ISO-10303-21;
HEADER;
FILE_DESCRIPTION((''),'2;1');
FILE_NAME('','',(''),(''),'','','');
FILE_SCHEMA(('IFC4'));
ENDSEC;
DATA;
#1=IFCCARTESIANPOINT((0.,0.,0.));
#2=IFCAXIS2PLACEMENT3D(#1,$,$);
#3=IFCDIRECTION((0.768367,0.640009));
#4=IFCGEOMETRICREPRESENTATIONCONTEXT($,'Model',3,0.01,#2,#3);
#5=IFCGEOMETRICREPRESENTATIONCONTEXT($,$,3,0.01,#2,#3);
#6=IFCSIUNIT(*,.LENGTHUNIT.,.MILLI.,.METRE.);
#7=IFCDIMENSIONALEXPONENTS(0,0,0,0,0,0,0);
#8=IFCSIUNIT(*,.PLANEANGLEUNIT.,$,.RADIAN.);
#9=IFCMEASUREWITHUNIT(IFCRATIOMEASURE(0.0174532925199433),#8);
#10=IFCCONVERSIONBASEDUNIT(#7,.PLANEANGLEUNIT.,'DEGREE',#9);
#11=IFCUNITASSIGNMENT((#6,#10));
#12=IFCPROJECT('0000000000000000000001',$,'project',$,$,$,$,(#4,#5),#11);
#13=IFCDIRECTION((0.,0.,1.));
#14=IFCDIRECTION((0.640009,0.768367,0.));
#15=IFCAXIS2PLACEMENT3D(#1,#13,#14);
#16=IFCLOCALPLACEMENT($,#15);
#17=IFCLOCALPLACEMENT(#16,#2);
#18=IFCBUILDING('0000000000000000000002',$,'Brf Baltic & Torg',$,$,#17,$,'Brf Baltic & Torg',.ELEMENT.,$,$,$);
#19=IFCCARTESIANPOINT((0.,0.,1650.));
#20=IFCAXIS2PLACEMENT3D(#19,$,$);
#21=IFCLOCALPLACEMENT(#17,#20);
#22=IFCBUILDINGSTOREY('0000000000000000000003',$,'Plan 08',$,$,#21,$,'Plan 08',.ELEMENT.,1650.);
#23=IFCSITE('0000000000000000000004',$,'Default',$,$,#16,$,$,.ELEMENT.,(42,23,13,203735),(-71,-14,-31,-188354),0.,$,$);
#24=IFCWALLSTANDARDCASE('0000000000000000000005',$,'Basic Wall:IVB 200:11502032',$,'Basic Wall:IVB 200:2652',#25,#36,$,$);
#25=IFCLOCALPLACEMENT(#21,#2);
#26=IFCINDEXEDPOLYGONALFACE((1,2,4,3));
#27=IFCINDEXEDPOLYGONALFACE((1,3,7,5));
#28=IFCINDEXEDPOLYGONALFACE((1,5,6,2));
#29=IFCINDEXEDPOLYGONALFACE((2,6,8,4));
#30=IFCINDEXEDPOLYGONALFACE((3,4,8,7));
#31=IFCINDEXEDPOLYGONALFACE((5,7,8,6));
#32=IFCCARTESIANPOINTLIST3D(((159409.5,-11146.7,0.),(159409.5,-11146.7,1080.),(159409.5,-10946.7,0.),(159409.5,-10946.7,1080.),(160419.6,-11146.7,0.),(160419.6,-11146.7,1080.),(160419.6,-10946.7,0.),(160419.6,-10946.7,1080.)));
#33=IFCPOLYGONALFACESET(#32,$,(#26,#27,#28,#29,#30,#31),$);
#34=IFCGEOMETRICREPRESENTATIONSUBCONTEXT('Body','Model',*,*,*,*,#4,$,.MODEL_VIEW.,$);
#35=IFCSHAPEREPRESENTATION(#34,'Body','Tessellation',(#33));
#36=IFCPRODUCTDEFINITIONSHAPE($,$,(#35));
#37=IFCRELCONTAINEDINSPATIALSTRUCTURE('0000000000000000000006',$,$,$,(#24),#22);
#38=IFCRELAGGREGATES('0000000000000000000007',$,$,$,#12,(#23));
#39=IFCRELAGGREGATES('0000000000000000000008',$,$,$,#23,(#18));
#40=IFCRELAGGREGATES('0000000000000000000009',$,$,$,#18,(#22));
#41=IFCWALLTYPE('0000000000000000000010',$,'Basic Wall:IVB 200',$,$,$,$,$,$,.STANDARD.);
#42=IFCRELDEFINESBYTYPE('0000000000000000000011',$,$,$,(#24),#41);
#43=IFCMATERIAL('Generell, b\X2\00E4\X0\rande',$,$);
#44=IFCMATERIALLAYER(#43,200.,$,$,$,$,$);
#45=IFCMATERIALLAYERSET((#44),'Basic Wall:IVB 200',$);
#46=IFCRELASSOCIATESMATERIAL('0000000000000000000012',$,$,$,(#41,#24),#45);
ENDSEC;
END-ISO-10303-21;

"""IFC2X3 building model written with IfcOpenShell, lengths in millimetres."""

from ifc_helpers import new_model, entity, si_unit, converted_unit, direction, frame, frame_2d, origin, place, context, subcontext, project, spatial, rectangle, extrude, clip, halfspace, material, layer, layer_set, layer_usage, type_object, element, save


model = new_model("IFC2X3")

# Units and contexts
model_context = context("Model", 3, precision=0.01, world=origin(), true_north=direction((0.768367, 0.640009)))
context_of_model = context(None, 3, precision=0.01, world=origin(), true_north=direction((0.768367, 0.640009)))
body_context = subcontext(model_context, "Body", "Model", "MODEL_VIEW")
ifc_project = project(units=[si_unit("LENGTHUNIT", "METRE", prefix="MILLI"), converted_unit("PLANEANGLEUNIT", "DEGREE", entity("IfcRatioMeasure", 0.0174532925199433), si_unit("PLANEANGLEUNIT", "RADIAN"), dimensions=[0, 0, 0, 0, 0, 0, 0])], contexts=[model_context, context_of_model])

# Site, building, storey
site_placement = place(None, frame((0.0, 0.0, 0.0), z_axis=(0.0, 0.0, 1.0), x_axis=(0.640009, 0.768367, 0.0)))
site = spatial("IfcSite", under=ifc_project, at=site_placement, Name="Default", CompositionType="ELEMENT", RefLatitude=(42, 23, 13, 203735), RefLongitude=(-71, -14, -31, -188354), RefElevation=0.0)
building_placement = place(site_placement, origin())
building = spatial("IfcBuilding", under=site, at=building_placement, Name="Brf Baltic & Torg", LongName="Brf Baltic & Torg", CompositionType="ELEMENT")
storey_placement = place(building_placement, frame((0.0, 0.0, 1650.0)))
storey = spatial("IfcBuildingStorey", under=building, at=storey_placement, Name="Plan 08", LongName="Plan 08", CompositionType="ELEMENT", Elevation=1650.0)

# Shared definitions
ifc_material_1 = material(Name="Generell, bärande")
ifc_layer = layer(ifc_material_1, 200.0)
ifc_layer_set = layer_set([ifc_layer], Name="Basic Wall:IVB 200")
wall_type = type_object("IfcWallType", Name="Basic Wall:IVB 200", PredefinedType="STANDARD", material=ifc_layer_set)

# Wall
ifc_layer_usage_1 = layer_usage(ifc_layer_set, "AXIS2", "NEGATIVE", 100.0)
wall_1_placement = place(storey_placement, frame((159409.5, -11046.7, 0.0)))
element("IfcWallStandardCase", 1, at=wall_1_placement, inside=storey, type_object=wall_type, material=ifc_layer_usage_1, Name="Basic Wall:IVB 200:11502032", ObjectType="Basic Wall:IVB 200:2652", context=body_context, shape_type="Clipping", body=[
    clip(extrude(rectangle(XDim=1010.1, YDim=200.0, at=frame_2d((505.0, 0.0), x_axis=(-1.0, 0.0))), origin(), (0.0, 0.0, 1.0), 1080.0), halfspace(origin(), True)),
])

save(model, "model.ifc")
